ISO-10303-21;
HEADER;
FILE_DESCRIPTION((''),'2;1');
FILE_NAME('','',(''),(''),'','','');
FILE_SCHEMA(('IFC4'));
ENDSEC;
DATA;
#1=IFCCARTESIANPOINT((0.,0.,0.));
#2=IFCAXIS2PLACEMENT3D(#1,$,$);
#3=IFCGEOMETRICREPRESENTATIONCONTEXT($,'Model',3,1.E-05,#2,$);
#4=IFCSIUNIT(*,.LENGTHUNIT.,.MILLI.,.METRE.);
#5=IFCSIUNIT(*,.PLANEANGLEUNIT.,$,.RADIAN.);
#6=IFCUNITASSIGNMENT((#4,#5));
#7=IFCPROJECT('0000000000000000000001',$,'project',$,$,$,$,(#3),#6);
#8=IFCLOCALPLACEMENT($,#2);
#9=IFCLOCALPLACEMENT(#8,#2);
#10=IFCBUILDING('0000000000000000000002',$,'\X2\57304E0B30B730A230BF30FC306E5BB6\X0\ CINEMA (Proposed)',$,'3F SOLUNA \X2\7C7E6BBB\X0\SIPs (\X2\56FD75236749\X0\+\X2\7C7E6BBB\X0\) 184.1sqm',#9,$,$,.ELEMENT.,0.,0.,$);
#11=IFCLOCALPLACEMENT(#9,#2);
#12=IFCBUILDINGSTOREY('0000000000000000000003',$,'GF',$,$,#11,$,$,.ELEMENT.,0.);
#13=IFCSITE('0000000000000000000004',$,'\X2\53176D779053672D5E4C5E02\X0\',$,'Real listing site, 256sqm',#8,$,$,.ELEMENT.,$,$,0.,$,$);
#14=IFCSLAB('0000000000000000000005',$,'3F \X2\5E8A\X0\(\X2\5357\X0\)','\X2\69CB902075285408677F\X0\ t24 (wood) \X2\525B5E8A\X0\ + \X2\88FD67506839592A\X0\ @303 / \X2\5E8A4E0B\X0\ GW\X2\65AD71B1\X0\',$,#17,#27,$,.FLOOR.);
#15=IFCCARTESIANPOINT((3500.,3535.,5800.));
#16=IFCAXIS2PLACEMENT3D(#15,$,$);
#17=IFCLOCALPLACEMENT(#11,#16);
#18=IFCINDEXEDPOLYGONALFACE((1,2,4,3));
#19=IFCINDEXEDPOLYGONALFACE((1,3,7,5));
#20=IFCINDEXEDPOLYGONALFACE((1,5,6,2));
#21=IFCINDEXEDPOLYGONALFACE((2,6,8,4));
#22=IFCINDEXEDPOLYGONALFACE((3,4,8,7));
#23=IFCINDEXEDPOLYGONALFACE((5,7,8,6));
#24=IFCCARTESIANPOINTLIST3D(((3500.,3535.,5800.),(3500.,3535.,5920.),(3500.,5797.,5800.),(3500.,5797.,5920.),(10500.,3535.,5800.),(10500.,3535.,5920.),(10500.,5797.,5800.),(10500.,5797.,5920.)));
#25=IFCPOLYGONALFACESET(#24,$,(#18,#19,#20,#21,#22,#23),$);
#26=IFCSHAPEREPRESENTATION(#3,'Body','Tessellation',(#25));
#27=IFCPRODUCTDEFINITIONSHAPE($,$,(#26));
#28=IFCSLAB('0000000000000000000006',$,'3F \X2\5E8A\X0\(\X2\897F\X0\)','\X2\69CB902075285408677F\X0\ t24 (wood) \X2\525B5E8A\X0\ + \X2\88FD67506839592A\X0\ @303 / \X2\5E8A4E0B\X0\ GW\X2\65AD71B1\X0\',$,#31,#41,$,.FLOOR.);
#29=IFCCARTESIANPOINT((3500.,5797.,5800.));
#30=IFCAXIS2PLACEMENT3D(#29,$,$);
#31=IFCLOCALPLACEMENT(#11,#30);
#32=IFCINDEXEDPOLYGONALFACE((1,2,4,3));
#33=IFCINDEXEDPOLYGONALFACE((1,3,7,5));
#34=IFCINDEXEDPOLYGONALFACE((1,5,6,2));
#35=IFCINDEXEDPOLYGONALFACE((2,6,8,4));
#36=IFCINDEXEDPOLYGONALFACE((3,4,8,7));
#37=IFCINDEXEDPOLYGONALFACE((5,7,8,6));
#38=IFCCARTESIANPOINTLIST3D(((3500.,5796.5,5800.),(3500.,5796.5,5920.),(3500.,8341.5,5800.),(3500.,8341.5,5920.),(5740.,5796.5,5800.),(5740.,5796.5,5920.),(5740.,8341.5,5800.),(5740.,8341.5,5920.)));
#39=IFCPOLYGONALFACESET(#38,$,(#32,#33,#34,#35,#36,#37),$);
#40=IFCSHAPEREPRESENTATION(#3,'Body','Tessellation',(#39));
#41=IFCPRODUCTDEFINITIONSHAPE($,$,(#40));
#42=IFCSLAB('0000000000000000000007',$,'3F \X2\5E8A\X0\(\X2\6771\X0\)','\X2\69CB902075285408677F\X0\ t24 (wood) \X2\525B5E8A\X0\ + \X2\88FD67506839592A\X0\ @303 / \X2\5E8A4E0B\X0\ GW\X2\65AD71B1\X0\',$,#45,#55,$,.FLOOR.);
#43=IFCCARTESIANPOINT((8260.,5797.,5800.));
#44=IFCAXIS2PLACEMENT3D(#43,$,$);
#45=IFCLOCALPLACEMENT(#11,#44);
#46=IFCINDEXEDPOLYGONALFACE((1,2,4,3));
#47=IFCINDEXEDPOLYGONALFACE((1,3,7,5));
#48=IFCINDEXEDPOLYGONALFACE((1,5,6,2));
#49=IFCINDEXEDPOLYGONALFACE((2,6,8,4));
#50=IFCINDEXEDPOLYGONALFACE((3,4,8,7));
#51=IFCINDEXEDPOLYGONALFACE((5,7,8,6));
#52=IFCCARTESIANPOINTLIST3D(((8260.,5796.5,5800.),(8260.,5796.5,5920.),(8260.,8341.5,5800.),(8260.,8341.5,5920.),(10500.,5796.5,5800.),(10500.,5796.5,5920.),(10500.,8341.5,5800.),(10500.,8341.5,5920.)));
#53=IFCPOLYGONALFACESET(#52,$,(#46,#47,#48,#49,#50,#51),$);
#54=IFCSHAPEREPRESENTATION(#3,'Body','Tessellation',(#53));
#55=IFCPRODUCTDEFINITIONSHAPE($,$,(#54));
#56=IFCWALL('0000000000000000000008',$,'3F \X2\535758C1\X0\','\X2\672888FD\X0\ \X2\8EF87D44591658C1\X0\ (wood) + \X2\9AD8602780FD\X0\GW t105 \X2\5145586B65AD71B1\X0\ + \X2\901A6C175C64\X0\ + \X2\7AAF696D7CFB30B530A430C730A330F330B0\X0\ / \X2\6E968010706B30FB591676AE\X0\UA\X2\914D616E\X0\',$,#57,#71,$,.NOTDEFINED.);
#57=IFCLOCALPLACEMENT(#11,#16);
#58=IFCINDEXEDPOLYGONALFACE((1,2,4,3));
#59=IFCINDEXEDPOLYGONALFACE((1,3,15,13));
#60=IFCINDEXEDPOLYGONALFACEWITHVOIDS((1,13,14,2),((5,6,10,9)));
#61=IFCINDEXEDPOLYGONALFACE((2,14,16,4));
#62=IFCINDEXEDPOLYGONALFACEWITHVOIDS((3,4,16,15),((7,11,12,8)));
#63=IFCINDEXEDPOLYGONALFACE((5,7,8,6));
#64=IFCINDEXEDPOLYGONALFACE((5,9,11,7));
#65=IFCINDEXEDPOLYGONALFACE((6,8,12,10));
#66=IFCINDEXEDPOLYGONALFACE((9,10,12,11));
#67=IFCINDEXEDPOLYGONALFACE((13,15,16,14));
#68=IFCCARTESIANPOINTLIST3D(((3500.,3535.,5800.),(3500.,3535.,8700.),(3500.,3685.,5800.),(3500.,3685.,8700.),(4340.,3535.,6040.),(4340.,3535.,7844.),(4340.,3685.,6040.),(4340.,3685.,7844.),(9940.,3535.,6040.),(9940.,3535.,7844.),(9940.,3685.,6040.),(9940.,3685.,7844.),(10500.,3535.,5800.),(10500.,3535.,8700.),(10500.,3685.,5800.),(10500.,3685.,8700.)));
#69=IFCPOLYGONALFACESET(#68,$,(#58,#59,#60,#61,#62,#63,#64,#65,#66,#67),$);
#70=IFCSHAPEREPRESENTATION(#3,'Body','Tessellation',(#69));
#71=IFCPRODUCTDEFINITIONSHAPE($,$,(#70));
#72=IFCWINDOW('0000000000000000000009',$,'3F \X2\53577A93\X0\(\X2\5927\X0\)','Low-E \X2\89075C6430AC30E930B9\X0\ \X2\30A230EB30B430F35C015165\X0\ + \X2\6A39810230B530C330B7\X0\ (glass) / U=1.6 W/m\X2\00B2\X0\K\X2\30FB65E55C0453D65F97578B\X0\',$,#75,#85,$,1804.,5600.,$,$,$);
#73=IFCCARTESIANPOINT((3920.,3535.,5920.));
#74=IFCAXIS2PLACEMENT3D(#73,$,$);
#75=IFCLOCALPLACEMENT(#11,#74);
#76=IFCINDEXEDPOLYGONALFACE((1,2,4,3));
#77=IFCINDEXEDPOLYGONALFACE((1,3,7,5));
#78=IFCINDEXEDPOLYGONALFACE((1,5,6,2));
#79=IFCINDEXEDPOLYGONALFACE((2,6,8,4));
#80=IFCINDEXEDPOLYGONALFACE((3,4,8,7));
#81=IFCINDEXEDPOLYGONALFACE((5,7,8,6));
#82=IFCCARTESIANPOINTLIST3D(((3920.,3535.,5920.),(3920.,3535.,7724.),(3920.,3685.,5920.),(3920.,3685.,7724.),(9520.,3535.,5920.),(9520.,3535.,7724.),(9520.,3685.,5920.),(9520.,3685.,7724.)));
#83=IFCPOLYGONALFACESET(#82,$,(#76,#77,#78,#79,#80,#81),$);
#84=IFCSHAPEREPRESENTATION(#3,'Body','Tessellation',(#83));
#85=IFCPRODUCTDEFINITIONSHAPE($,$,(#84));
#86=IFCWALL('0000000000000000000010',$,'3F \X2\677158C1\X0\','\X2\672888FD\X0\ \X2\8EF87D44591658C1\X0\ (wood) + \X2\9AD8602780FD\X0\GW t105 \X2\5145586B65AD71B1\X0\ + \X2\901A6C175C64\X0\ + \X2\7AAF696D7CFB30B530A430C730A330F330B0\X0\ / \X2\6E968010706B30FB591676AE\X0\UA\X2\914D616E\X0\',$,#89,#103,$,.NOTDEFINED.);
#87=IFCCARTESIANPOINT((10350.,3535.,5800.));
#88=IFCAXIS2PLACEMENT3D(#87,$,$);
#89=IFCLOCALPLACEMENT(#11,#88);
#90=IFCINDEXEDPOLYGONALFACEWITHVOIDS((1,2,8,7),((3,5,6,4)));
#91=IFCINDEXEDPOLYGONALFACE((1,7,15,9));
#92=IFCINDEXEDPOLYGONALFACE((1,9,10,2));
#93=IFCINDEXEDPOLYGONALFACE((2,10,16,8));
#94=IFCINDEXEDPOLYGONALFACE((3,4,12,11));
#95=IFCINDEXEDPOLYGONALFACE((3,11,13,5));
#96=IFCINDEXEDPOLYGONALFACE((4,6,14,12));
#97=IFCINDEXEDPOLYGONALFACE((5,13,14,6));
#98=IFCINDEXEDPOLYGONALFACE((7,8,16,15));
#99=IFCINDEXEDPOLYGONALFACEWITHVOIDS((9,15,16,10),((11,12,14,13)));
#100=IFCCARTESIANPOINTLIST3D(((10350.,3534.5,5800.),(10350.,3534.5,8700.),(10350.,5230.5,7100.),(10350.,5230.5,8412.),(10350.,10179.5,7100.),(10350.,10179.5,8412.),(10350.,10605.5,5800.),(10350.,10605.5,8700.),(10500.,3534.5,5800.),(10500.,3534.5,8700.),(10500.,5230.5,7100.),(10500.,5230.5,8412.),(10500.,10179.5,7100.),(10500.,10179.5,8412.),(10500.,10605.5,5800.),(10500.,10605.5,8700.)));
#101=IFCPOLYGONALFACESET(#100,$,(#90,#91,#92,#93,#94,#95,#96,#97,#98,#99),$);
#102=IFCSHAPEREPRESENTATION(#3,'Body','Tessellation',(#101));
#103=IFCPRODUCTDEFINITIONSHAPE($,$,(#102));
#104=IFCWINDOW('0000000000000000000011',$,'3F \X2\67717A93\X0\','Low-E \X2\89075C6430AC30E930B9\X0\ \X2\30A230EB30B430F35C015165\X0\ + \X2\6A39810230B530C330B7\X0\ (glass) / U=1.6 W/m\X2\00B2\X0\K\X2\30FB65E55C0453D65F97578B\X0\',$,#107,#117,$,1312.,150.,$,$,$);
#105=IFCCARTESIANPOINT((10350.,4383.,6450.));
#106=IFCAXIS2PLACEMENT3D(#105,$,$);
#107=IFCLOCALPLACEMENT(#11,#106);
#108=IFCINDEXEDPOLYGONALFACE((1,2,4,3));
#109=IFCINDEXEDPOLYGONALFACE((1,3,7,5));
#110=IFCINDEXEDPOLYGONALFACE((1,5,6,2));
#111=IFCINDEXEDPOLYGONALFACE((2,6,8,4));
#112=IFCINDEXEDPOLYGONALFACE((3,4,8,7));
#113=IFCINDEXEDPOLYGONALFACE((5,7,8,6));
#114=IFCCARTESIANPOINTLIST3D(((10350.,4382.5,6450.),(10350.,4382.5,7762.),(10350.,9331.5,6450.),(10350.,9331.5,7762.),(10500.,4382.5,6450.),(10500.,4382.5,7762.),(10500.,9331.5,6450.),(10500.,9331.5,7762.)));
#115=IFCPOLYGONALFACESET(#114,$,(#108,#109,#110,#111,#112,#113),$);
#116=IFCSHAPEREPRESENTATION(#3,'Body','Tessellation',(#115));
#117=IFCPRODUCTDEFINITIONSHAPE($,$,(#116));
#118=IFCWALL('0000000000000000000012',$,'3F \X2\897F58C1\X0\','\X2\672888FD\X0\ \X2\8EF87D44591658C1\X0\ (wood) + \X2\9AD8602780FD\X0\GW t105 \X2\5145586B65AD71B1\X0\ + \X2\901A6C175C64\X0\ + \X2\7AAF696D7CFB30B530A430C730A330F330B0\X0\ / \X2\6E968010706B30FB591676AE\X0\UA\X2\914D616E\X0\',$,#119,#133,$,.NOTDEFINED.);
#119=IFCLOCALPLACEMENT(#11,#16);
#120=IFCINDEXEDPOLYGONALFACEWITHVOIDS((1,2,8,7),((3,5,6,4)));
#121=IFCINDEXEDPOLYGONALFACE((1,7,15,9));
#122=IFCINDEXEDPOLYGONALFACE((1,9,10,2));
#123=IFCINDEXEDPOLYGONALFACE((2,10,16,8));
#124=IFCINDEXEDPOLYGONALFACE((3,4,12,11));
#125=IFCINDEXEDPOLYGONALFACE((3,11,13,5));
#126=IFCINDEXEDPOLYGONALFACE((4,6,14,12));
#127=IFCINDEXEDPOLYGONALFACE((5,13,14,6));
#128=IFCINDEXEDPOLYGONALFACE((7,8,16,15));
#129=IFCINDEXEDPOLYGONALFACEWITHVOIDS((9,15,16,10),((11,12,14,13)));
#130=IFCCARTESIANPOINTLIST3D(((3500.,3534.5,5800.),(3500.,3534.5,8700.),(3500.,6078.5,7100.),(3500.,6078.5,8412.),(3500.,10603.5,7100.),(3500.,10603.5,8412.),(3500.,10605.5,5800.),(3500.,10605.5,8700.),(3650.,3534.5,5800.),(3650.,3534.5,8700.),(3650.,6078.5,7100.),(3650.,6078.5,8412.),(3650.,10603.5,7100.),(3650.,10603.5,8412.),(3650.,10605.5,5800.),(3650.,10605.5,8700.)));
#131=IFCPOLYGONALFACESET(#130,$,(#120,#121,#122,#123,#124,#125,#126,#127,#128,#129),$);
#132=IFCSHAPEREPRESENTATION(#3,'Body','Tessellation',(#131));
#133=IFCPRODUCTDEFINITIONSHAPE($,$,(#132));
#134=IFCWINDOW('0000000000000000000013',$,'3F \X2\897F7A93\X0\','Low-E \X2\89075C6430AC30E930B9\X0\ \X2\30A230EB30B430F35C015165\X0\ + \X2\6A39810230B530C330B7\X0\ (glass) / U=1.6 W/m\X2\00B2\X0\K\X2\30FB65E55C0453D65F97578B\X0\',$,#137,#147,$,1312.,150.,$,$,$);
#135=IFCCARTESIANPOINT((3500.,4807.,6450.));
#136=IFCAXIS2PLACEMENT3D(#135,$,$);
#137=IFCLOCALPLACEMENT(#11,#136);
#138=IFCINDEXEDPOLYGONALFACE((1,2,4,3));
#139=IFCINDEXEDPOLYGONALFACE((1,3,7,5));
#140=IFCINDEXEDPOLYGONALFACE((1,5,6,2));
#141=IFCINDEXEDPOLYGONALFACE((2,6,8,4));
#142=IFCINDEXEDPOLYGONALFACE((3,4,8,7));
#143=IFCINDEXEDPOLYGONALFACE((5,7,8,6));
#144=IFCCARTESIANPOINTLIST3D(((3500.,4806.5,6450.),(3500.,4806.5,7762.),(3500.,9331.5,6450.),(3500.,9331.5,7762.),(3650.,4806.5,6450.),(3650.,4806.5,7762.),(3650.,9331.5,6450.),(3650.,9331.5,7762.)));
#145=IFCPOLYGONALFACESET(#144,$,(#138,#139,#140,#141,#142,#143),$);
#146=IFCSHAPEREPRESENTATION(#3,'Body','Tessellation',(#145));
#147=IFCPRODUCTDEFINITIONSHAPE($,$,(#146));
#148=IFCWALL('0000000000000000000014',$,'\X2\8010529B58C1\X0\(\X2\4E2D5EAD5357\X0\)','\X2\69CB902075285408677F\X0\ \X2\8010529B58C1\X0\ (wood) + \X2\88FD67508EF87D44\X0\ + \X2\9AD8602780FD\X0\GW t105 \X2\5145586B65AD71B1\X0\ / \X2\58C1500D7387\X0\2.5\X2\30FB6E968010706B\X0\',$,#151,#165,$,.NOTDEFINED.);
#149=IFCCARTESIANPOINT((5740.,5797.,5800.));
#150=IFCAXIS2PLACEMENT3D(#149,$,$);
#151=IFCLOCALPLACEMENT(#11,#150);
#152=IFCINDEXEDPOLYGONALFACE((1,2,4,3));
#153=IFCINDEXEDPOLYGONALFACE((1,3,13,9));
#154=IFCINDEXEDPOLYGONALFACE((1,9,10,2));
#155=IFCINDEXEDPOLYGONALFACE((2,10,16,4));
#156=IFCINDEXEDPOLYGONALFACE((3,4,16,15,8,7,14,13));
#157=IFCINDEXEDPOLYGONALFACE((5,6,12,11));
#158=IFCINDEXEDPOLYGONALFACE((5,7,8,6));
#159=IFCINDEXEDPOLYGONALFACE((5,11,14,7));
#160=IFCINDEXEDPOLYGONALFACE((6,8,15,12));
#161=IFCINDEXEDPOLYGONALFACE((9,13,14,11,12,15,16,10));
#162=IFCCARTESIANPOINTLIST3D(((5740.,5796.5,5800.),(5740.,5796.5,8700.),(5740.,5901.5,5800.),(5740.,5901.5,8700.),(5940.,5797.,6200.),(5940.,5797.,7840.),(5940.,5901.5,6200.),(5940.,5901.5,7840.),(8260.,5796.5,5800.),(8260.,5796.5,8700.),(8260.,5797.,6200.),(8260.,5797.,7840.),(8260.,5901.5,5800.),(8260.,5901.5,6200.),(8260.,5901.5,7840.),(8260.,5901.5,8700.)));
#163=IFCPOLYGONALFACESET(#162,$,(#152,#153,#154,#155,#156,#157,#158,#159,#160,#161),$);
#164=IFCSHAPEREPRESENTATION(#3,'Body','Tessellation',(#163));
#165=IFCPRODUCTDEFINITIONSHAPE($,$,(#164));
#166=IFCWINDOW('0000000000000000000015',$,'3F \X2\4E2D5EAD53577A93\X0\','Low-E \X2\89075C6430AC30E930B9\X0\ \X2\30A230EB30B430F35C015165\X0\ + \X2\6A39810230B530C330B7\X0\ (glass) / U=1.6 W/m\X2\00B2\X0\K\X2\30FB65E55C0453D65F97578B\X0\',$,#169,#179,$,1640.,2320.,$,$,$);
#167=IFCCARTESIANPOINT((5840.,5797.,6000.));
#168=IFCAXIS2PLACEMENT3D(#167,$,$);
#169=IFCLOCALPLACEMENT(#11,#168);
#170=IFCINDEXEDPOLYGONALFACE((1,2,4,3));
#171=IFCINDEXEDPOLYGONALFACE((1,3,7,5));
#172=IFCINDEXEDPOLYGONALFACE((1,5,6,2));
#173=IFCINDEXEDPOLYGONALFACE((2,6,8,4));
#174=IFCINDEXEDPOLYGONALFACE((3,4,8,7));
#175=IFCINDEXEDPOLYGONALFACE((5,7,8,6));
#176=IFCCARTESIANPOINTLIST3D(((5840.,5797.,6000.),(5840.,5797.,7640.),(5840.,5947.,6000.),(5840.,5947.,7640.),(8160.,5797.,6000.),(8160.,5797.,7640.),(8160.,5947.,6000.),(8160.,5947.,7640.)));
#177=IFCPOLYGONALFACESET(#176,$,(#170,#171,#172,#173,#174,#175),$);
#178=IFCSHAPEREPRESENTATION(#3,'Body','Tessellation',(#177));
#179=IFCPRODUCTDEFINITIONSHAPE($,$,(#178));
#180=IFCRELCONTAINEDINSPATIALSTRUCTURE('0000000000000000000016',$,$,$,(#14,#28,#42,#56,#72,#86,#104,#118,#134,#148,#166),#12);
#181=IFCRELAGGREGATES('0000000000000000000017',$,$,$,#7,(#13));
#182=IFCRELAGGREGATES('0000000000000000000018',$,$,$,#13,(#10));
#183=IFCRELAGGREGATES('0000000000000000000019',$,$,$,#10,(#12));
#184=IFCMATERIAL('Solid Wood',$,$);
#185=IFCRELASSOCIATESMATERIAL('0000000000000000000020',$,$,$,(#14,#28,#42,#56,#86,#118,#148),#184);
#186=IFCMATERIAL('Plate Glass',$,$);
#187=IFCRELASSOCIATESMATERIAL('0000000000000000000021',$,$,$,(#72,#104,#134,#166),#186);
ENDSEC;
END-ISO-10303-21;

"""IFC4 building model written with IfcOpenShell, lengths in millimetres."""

from ifc_helpers import new_model, si_unit, frame, frame_2d, origin, place, context, project, spatial, rectangle, extrude, material, element, fill, save


model = new_model("IFC4")

# Units and contexts
model_context = context("Model", 3, precision=1e-05, world=origin())
ifc_project = project(units=[si_unit("LENGTHUNIT", "METRE", prefix="MILLI"), si_unit("PLANEANGLEUNIT", "RADIAN")], contexts=[model_context])

# Site, building, storey
site_placement = place(None, origin())
site = spatial("IfcSite", under=ifc_project, at=site_placement, Name="北海道札幌市", ObjectType="Real listing site, 256sqm", CompositionType="ELEMENT", RefElevation=0.0)
building_placement = place(site_placement, origin())
building = spatial("IfcBuilding", under=site, at=building_placement, Name="地下シアターの家 CINEMA (Proposed)", ObjectType="3F SOLUNA 籾殻SIPs (国産杉+籾殻) 184.1sqm", CompositionType="ELEMENT", ElevationOfRefHeight=0.0, ElevationOfTerrain=0.0)
storey_placement = place(building_placement, origin())
storey = spatial("IfcBuildingStorey", under=building, at=storey_placement, Name="GF", CompositionType="ELEMENT", Elevation=0.0)

# Slabs
ifc_material_1 = material(Name="Solid Wood")
slab_1_placement = place(storey_placement, frame((3500.0, 3535.0, 5800.0)))
element("IfcSlab", 1, at=slab_1_placement, inside=storey, material=ifc_material_1, Name="3F 床(南)", Description="構造用合板 t24 (wood) 剛床 + 製材根太 @303 / 床下 GW断熱", PredefinedType="FLOOR", context=model_context, shape_type="SweptSolid", body=[
    extrude(rectangle(XDim=7000.0, YDim=2262.0, at=frame_2d((3500.0, 1131.0))), frame((3500.0, 3535.0, 5800.0)), (0.0, 0.0, 1.0), 120.0),
])
slab_2_placement = place(storey_placement, frame((3500.0, 5797.0, 5800.0)))
element("IfcSlab", 2, at=slab_2_placement, inside=storey, material=ifc_material_1, Name="3F 床(西)", Description="構造用合板 t24 (wood) 剛床 + 製材根太 @303 / 床下 GW断熱", PredefinedType="FLOOR", context=model_context, shape_type="SweptSolid", body=[
    extrude(rectangle(XDim=2240.0, YDim=2545.0, at=frame_2d((1120.0, 1272.0))), frame((3500.0, 5797.0, 5800.0)), (0.0, 0.0, 1.0), 120.0),
])
slab_3_placement = place(storey_placement, frame((8260.0, 5797.0, 5800.0)))
element("IfcSlab", 3, at=slab_3_placement, inside=storey, material=ifc_material_1, Name="3F 床(東)", Description="構造用合板 t24 (wood) 剛床 + 製材根太 @303 / 床下 GW断熱", PredefinedType="FLOOR", context=model_context, shape_type="SweptSolid", body=[
    extrude(rectangle(XDim=2240.0, YDim=2545.0, at=frame_2d((1120.0, 1272.0))), frame((8260.0, 5797.0, 5800.0)), (0.0, 0.0, 1.0), 120.0),
])

# Walls, openings, windows
wall_1_placement = place(storey_placement, frame((3500.0, 3535.0, 5800.0)))
wall_1 = element("IfcWall", 4, at=wall_1_placement, inside=storey, material=ifc_material_1, Name="3F 南壁", Description="木製 軸組外壁 (wood) + 高性能GW t105 充填断熱 + 通気層 + 窯業系サイディング / 準耐火・外皮UA配慮", PredefinedType="NOTDEFINED", context=model_context, shape_type="SweptSolid", body=[
    extrude(rectangle(XDim=7000.0, YDim=150.0, at=frame_2d((3500.0, 75.0))), frame((3500.0, 3535.0, 5800.0)), (0.0, 0.0, 1.0), 2900.0),
])
opening_1_placement = place(storey_placement, frame((3920.0, 3535.0, 5920.0)))
opening_1 = element("IfcOpeningElement", 5, at=opening_1_placement, cuts=wall_1, PredefinedType="NOTDEFINED", context=model_context, shape_type="SweptSolid", body=[
    extrude(rectangle(XDim=5600.0, YDim=150.0, at=frame_2d((2800.0, 75.0))), frame((3920.0, 3535.0, 5920.0)), (0.0, 0.0, 1.0), 1804.0),
])
ifc_material_2 = material(Name="Plate Glass")
window_1_placement = place(storey_placement, frame((3920.0, 3535.0, 5920.0)))
window_1 = element("IfcWindow", 6, at=window_1_placement, inside=storey, material=ifc_material_2, Name="3F 南窓(大)", Description="Low-E 複層ガラス アルゴン封入 + 樹脂サッシ (glass) / U=1.6 W/m²K・日射取得型", OverallHeight=1804.0, OverallWidth=5600.0, context=model_context, shape_type="SweptSolid", body=[
    extrude(rectangle(XDim=5600.0, YDim=150.0, at=frame_2d((2800.0, 75.0))), frame((3920.0, 3535.0, 5920.0)), (0.0, 0.0, 1.0), 1804.0),
])
fill(opening_1, window_1)
wall_2_placement = place(storey_placement, frame((10350.0, 3535.0, 5800.0)))
wall_2 = element("IfcWall", 7, at=wall_2_placement, inside=storey, material=ifc_material_1, Name="3F 東壁", Description="木製 軸組外壁 (wood) + 高性能GW t105 充填断熱 + 通気層 + 窯業系サイディング / 準耐火・外皮UA配慮", PredefinedType="NOTDEFINED", context=model_context, shape_type="SweptSolid", body=[
    extrude(rectangle(XDim=150.0, YDim=7071.0, at=frame_2d((75.0, 3535.0))), frame((10350.0, 3535.0, 5800.0)), (0.0, 0.0, 1.0), 2900.0),
])
opening_2_placement = place(storey_placement, frame((10350.0, 4383.0, 6450.0)))
opening_2 = element("IfcOpeningElement", 8, at=opening_2_placement, cuts=wall_2, PredefinedType="NOTDEFINED", context=model_context, shape_type="SweptSolid", body=[
    extrude(rectangle(XDim=150.0, YDim=4949.0, at=frame_2d((75.0, 2474.0))), frame((10350.0, 4383.0, 6450.0)), (0.0, 0.0, 1.0), 1312.0),
])
window_2_placement = place(storey_placement, frame((10350.0, 4383.0, 6450.0)))
window_2 = element("IfcWindow", 9, at=window_2_placement, inside=storey, material=ifc_material_2, Name="3F 東窓", Description="Low-E 複層ガラス アルゴン封入 + 樹脂サッシ (glass) / U=1.6 W/m²K・日射取得型", OverallHeight=1312.0, OverallWidth=150.0, context=model_context, shape_type="SweptSolid", body=[
    extrude(rectangle(XDim=150.0, YDim=4949.0, at=frame_2d((75.0, 2474.0))), frame((10350.0, 4383.0, 6450.0)), (0.0, 0.0, 1.0), 1312.0),
])
fill(opening_2, window_2)
wall_3_placement = place(storey_placement, frame((3500.0, 3535.0, 5800.0)))
wall_3 = element("IfcWall", 10, at=wall_3_placement, inside=storey, material=ifc_material_1, Name="3F 西壁", Description="木製 軸組外壁 (wood) + 高性能GW t105 充填断熱 + 通気層 + 窯業系サイディング / 準耐火・外皮UA配慮", PredefinedType="NOTDEFINED", context=model_context, shape_type="SweptSolid", body=[
    extrude(rectangle(XDim=150.0, YDim=7071.0, at=frame_2d((75.0, 3535.0))), frame((3500.0, 3535.0, 5800.0)), (0.0, 0.0, 1.0), 2900.0),
])
opening_3_placement = place(storey_placement, frame((3500.0, 4807.0, 6450.0)))
opening_3 = element("IfcOpeningElement", 11, at=opening_3_placement, cuts=wall_3, PredefinedType="NOTDEFINED", context=model_context, shape_type="SweptSolid", body=[
    extrude(rectangle(XDim=150.0, YDim=4525.0, at=frame_2d((75.0, 2262.0))), frame((3500.0, 4807.0, 6450.0)), (0.0, 0.0, 1.0), 1312.0),
])
window_3_placement = place(storey_placement, frame((3500.0, 4807.0, 6450.0)))
window_3 = element("IfcWindow", 12, at=window_3_placement, inside=storey, material=ifc_material_2, Name="3F 西窓", Description="Low-E 複層ガラス アルゴン封入 + 樹脂サッシ (glass) / U=1.6 W/m²K・日射取得型", OverallHeight=1312.0, OverallWidth=150.0, context=model_context, shape_type="SweptSolid", body=[
    extrude(rectangle(XDim=150.0, YDim=4525.0, at=frame_2d((75.0, 2262.0))), frame((3500.0, 4807.0, 6450.0)), (0.0, 0.0, 1.0), 1312.0),
])
fill(opening_3, window_3)
wall_4_placement = place(storey_placement, frame((5740.0, 5797.0, 5800.0)))
wall_4 = element("IfcWall", 13, at=wall_4_placement, inside=storey, material=ifc_material_1, Name="耐力壁(中庭南)", Description="構造用合板 耐力壁 (wood) + 製材軸組 + 高性能GW t105 充填断熱 / 壁倍率2.5・準耐火", PredefinedType="NOTDEFINED", context=model_context, shape_type="SweptSolid", body=[
    extrude(rectangle(XDim=2520.0, YDim=105.0, at=frame_2d((1260.0, 52.0))), frame((5740.0, 5797.0, 5800.0)), (0.0, 0.0, 1.0), 2900.0),
])
opening_4_placement = place(storey_placement, frame((5840.0, 5797.0, 6000.0)))
opening_4 = element("IfcOpeningElement", 14, at=opening_4_placement, cuts=wall_4, PredefinedType="NOTDEFINED", context=model_context, shape_type="SweptSolid", body=[
    extrude(rectangle(XDim=2320.0, YDim=150.0, at=frame_2d((1160.0, 75.0))), frame((5840.0, 5797.0, 6000.0)), (0.0, 0.0, 1.0), 1640.0),
])
window_4_placement = place(storey_placement, frame((5840.0, 5797.0, 6000.0)))
window_4 = element("IfcWindow", 15, at=window_4_placement, inside=storey, material=ifc_material_2, Name="3F 中庭南窓", Description="Low-E 複層ガラス アルゴン封入 + 樹脂サッシ (glass) / U=1.6 W/m²K・日射取得型", OverallHeight=1640.0, OverallWidth=2320.0, context=model_context, shape_type="SweptSolid", body=[
    extrude(rectangle(XDim=2320.0, YDim=150.0, at=frame_2d((1160.0, 75.0))), frame((5840.0, 5797.0, 6000.0)), (0.0, 0.0, 1.0), 1640.0),
])
fill(opening_4, window_4)

save(model, "model.ifc")
